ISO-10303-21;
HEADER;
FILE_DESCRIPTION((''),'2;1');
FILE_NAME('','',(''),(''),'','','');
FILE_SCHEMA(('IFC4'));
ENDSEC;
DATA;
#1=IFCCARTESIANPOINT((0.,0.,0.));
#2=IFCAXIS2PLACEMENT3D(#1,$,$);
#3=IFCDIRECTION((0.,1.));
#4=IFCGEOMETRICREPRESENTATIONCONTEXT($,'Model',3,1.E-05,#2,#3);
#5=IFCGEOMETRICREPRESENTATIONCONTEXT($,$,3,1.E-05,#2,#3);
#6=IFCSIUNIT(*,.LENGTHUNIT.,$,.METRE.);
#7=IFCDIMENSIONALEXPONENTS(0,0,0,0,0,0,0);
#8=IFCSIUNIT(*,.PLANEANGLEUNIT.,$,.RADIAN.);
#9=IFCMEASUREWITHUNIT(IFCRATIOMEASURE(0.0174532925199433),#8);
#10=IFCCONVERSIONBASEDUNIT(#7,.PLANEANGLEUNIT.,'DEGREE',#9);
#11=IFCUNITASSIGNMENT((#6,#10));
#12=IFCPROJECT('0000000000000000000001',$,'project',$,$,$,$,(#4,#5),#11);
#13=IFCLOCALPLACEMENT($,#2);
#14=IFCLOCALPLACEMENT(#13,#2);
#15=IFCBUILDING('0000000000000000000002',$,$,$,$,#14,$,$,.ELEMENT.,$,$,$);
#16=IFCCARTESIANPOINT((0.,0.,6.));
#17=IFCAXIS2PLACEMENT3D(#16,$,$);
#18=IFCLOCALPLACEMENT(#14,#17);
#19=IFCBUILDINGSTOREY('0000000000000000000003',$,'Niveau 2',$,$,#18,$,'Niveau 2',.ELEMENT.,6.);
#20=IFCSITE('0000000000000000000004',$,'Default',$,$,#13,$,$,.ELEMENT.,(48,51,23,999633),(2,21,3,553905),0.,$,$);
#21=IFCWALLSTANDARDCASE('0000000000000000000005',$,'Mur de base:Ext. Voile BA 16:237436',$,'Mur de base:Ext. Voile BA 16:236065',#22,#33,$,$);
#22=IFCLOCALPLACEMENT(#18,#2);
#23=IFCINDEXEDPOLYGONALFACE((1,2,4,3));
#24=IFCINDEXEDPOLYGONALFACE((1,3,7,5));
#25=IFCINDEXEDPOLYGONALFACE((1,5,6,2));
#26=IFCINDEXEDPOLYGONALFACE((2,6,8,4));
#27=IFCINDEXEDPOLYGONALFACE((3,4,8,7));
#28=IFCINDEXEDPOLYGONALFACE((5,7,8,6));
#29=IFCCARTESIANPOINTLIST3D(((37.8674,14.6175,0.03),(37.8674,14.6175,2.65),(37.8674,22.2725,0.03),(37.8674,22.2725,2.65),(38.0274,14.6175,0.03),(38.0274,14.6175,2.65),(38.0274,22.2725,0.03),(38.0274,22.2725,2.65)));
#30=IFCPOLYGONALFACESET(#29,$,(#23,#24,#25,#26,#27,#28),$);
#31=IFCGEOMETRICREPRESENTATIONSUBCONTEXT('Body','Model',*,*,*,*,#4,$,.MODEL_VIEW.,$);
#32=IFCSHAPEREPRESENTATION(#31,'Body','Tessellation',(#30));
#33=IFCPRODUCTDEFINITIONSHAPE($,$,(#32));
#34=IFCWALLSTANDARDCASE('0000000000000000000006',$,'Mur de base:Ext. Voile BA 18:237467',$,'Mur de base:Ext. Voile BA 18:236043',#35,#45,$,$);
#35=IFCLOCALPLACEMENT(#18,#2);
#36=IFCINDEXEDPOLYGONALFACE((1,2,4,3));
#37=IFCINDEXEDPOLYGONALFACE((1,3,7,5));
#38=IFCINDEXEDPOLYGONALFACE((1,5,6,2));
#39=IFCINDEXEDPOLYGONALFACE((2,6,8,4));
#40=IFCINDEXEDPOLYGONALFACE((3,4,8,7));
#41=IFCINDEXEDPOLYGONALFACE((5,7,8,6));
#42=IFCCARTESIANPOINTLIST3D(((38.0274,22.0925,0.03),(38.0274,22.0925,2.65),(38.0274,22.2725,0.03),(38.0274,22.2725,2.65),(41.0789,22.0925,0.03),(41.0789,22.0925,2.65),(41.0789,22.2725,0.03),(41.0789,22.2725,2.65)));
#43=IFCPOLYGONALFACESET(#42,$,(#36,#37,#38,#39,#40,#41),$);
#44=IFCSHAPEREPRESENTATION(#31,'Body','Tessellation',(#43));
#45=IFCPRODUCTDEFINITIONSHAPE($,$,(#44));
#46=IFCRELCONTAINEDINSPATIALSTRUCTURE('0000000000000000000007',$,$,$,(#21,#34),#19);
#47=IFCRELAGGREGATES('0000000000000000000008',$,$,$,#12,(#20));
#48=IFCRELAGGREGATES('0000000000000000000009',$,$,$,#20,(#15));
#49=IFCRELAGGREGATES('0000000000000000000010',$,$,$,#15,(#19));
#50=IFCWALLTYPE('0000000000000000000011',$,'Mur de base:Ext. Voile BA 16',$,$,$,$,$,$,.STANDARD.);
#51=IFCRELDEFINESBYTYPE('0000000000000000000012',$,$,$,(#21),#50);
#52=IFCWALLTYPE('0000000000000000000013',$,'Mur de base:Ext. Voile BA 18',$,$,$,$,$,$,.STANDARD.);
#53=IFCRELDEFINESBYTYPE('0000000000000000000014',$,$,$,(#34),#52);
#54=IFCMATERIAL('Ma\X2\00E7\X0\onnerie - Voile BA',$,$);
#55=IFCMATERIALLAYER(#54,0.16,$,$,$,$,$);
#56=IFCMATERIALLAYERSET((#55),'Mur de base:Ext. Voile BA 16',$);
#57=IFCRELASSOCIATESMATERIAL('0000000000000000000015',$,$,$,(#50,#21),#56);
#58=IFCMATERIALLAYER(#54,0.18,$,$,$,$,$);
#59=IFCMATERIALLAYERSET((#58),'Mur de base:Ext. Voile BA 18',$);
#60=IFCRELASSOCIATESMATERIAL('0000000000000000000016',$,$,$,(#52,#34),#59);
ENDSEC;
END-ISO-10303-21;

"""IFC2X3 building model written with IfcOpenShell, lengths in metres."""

from ifc_helpers import new_model, entity, si_unit, converted_unit, direction, frame, frame_2d, origin, place, context, subcontext, project, spatial, rectangle, extrude, material, layer, layer_set, layer_usage, type_object, element, save


model = new_model("IFC2X3")

# Units and contexts
model_context = context("Model", 3, precision=1e-05, world=origin(), true_north=direction((0.0, 1.0)))
context_of_model = context(None, 3, precision=1e-05, world=origin(), true_north=direction((0.0, 1.0)))
body_context = subcontext(model_context, "Body", "Model", "MODEL_VIEW")
ifc_project = project(units=[si_unit("LENGTHUNIT", "METRE"), converted_unit("PLANEANGLEUNIT", "DEGREE", entity("IfcRatioMeasure", 0.0174532925199433), si_unit("PLANEANGLEUNIT", "RADIAN"), dimensions=[0, 0, 0, 0, 0, 0, 0])], contexts=[model_context, context_of_model])

# Site, building, storey
site_placement = place(None, origin())
site = spatial("IfcSite", under=ifc_project, at=site_placement, Name="Default", CompositionType="ELEMENT", RefLatitude=(48, 51, 23, 999633), RefLongitude=(2, 21, 3, 553905), RefElevation=0.0)
building_placement = place(site_placement, origin())
building = spatial("IfcBuilding", under=site, at=building_placement, CompositionType="ELEMENT")
storey_placement = place(building_placement, frame((0.0, 0.0, 6.0)))
storey = spatial("IfcBuildingStorey", under=building, at=storey_placement, Name="Niveau 2", LongName="Niveau 2", CompositionType="ELEMENT", Elevation=6.0)

# Shared definitions
ifc_material_1 = material(Name="Maçonnerie - Voile BA")
ifc_layer_1 = layer(ifc_material_1, 0.16)
ifc_layer_set_1 = layer_set([ifc_layer_1], Name="Mur de base:Ext. Voile BA 16")
wall_type_1 = type_object("IfcWallType", Name="Mur de base:Ext. Voile BA 16", PredefinedType="STANDARD", material=ifc_layer_set_1)

# Walls
ifc_layer_usage_1 = layer_usage(ifc_layer_set_1, "AXIS2", "NEGATIVE", 0.08)
wall_1_placement = place(storey_placement, frame((37.9474, 14.6175, 0.03), z_axis=(0.0, 0.0, 1.0), x_axis=(0.0, 1.0, 0.0)))
element("IfcWallStandardCase", 1, at=wall_1_placement, inside=storey, type_object=wall_type_1, material=ifc_layer_usage_1, Name="Mur de base:Ext. Voile BA 16:237436", ObjectType="Mur de base:Ext. Voile BA 16:236065", context=body_context, shape_type="SweptSolid", body=[
    extrude(rectangle(XDim=7.655, YDim=0.16, at=frame_2d((3.8275, 0.0), x_axis=(-1.0, 0.0))), origin(), (0.0, 0.0, 1.0), 2.62),
])
ifc_layer_2 = layer(ifc_material_1, 0.18)
ifc_layer_set_2 = layer_set([ifc_layer_2], Name="Mur de base:Ext. Voile BA 18")
ifc_layer_usage_2 = layer_usage(ifc_layer_set_2, "AXIS2", "POSITIVE", -0.09)
wall_type_2 = type_object("IfcWallType", Name="Mur de base:Ext. Voile BA 18", PredefinedType="STANDARD", material=ifc_layer_set_2)
wall_2_placement = place(storey_placement, frame((41.0789, 22.1825, 0.03), z_axis=(0.0, 0.0, 1.0), x_axis=(-1.0, 0.0, 0.0)))
element("IfcWallStandardCase", 2, at=wall_2_placement, inside=storey, type_object=wall_type_2, material=ifc_layer_usage_2, Name="Mur de base:Ext. Voile BA 18:237467", ObjectType="Mur de base:Ext. Voile BA 18:236043", context=body_context, shape_type="SweptSolid", body=[
    extrude(rectangle(XDim=3.0515, YDim=0.18, at=frame_2d((1.5257, 0.0), x_axis=(-1.0, 0.0))), origin(), (0.0, 0.0, 1.0), 2.62),
])

save(model, "model.ifc")
